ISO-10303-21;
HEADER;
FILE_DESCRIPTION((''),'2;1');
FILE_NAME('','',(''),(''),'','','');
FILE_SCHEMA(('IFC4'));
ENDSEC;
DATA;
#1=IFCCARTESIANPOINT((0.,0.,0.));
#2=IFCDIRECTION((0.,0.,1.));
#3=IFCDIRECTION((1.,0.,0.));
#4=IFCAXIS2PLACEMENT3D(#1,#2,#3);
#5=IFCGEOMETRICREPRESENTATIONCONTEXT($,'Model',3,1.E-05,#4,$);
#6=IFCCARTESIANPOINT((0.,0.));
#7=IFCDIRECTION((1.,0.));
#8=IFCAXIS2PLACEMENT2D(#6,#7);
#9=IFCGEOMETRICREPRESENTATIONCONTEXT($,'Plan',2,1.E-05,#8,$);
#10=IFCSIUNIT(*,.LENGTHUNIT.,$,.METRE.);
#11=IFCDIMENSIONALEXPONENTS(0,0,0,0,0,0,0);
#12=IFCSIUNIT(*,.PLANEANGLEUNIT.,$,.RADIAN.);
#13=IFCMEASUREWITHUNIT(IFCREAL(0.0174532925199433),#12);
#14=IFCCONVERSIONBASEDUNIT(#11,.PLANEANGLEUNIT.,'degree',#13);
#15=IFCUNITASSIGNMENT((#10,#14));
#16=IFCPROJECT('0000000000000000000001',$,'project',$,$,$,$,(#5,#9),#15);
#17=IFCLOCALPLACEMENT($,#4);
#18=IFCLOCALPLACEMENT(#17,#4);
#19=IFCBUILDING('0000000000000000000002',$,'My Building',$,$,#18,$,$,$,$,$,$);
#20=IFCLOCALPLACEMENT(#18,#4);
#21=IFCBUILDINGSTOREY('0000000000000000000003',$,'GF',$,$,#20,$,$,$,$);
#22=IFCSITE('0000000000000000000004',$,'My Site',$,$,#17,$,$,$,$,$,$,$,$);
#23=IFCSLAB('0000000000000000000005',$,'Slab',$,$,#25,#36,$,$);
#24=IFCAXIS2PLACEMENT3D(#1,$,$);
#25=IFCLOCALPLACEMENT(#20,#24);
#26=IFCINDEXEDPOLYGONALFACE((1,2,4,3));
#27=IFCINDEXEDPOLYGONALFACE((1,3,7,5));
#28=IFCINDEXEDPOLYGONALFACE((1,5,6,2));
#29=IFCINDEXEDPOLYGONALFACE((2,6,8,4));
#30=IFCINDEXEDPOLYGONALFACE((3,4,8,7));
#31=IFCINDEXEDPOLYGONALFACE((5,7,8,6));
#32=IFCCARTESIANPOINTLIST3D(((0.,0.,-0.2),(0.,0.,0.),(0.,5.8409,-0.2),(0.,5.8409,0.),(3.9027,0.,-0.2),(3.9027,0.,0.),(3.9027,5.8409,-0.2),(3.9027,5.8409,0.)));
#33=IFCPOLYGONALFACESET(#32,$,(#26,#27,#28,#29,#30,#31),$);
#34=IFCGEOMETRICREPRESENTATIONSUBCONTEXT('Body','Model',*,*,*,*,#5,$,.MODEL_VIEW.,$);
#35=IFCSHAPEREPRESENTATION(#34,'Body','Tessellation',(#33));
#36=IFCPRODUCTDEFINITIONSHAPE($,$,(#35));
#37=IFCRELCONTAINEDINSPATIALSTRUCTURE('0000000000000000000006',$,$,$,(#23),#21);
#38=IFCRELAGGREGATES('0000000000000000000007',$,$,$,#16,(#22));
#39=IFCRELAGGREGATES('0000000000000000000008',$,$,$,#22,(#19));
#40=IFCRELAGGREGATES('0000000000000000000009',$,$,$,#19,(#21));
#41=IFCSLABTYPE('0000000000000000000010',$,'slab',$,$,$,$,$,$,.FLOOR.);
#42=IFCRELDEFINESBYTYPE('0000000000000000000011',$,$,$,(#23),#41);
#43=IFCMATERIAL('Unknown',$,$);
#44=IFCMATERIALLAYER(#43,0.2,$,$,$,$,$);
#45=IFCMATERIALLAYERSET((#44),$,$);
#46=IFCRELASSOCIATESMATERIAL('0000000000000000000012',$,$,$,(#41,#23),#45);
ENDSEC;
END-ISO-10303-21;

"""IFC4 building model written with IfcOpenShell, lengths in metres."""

from ifc_helpers import new_model, entity, si_unit, converted_unit, frame, origin_with_axes, origin_2d_with_axis, place, context, subcontext, project, spatial, line, indexed_curve, outline, extrude, material, layer, layer_set, layer_usage, type_object, element, save


model = new_model("IFC4")

# Units and contexts
model_context = context("Model", 3, precision=1e-05, world=origin_with_axes())
plan_context = context("Plan", 2, precision=1e-05, world=origin_2d_with_axis())
body_context = subcontext(model_context, "Body", "Model", "MODEL_VIEW")
ifc_project = project(units=[si_unit("LENGTHUNIT", "METRE"), converted_unit("PLANEANGLEUNIT", "degree", entity("IfcReal", 0.0174532925199433), si_unit("PLANEANGLEUNIT", "RADIAN"), dimensions=[0, 0, 0, 0, 0, 0, 0])], contexts=[model_context, plan_context])

# Site, building, storey
site_placement = place(None, origin_with_axes())
site = spatial("IfcSite", under=ifc_project, at=site_placement, Name="My Site")
building_placement = place(site_placement, origin_with_axes())
building = spatial("IfcBuilding", under=site, at=building_placement, Name="My Building")
storey_placement = place(building_placement, origin_with_axes())
storey = spatial("IfcBuildingStorey", under=building, at=storey_placement, Name="GF")

# Slab
ifc_material = material(Name="Unknown")
ifc_layer = layer(ifc_material, 0.2)
ifc_layer_set = layer_set([ifc_layer])
ifc_layer_usage = layer_usage(ifc_layer_set, "AXIS3", "POSITIVE", 0.0)
slab_type = type_object("IfcSlabType", Name="slab", PredefinedType="FLOOR", material=ifc_layer_set)
slab_placement = place(storey_placement, frame((0.0, 0.0, -0.2), z_axis=(0.0, 0.0, 1.0), x_axis=(1.0, 0.0, 0.0)))
element("IfcSlab", 1, at=slab_placement, inside=storey, type_object=slab_type, material=ifc_layer_usage, Name="Slab", context=body_context, shape_type="SweptSolid", body=[
    extrude(outline(indexed_curve([(0.0, 0.0), (3.9027, 0.0), (3.9027, 5.8409), (0.0, 5.8409)], segments=[line(3, 2), line(2, 1), line(1, 4), line(4, 3)], self_intersect=False)), None, (0.0, 0.0, 1.0), 0.2),
])

save(model, "model.ifc")
